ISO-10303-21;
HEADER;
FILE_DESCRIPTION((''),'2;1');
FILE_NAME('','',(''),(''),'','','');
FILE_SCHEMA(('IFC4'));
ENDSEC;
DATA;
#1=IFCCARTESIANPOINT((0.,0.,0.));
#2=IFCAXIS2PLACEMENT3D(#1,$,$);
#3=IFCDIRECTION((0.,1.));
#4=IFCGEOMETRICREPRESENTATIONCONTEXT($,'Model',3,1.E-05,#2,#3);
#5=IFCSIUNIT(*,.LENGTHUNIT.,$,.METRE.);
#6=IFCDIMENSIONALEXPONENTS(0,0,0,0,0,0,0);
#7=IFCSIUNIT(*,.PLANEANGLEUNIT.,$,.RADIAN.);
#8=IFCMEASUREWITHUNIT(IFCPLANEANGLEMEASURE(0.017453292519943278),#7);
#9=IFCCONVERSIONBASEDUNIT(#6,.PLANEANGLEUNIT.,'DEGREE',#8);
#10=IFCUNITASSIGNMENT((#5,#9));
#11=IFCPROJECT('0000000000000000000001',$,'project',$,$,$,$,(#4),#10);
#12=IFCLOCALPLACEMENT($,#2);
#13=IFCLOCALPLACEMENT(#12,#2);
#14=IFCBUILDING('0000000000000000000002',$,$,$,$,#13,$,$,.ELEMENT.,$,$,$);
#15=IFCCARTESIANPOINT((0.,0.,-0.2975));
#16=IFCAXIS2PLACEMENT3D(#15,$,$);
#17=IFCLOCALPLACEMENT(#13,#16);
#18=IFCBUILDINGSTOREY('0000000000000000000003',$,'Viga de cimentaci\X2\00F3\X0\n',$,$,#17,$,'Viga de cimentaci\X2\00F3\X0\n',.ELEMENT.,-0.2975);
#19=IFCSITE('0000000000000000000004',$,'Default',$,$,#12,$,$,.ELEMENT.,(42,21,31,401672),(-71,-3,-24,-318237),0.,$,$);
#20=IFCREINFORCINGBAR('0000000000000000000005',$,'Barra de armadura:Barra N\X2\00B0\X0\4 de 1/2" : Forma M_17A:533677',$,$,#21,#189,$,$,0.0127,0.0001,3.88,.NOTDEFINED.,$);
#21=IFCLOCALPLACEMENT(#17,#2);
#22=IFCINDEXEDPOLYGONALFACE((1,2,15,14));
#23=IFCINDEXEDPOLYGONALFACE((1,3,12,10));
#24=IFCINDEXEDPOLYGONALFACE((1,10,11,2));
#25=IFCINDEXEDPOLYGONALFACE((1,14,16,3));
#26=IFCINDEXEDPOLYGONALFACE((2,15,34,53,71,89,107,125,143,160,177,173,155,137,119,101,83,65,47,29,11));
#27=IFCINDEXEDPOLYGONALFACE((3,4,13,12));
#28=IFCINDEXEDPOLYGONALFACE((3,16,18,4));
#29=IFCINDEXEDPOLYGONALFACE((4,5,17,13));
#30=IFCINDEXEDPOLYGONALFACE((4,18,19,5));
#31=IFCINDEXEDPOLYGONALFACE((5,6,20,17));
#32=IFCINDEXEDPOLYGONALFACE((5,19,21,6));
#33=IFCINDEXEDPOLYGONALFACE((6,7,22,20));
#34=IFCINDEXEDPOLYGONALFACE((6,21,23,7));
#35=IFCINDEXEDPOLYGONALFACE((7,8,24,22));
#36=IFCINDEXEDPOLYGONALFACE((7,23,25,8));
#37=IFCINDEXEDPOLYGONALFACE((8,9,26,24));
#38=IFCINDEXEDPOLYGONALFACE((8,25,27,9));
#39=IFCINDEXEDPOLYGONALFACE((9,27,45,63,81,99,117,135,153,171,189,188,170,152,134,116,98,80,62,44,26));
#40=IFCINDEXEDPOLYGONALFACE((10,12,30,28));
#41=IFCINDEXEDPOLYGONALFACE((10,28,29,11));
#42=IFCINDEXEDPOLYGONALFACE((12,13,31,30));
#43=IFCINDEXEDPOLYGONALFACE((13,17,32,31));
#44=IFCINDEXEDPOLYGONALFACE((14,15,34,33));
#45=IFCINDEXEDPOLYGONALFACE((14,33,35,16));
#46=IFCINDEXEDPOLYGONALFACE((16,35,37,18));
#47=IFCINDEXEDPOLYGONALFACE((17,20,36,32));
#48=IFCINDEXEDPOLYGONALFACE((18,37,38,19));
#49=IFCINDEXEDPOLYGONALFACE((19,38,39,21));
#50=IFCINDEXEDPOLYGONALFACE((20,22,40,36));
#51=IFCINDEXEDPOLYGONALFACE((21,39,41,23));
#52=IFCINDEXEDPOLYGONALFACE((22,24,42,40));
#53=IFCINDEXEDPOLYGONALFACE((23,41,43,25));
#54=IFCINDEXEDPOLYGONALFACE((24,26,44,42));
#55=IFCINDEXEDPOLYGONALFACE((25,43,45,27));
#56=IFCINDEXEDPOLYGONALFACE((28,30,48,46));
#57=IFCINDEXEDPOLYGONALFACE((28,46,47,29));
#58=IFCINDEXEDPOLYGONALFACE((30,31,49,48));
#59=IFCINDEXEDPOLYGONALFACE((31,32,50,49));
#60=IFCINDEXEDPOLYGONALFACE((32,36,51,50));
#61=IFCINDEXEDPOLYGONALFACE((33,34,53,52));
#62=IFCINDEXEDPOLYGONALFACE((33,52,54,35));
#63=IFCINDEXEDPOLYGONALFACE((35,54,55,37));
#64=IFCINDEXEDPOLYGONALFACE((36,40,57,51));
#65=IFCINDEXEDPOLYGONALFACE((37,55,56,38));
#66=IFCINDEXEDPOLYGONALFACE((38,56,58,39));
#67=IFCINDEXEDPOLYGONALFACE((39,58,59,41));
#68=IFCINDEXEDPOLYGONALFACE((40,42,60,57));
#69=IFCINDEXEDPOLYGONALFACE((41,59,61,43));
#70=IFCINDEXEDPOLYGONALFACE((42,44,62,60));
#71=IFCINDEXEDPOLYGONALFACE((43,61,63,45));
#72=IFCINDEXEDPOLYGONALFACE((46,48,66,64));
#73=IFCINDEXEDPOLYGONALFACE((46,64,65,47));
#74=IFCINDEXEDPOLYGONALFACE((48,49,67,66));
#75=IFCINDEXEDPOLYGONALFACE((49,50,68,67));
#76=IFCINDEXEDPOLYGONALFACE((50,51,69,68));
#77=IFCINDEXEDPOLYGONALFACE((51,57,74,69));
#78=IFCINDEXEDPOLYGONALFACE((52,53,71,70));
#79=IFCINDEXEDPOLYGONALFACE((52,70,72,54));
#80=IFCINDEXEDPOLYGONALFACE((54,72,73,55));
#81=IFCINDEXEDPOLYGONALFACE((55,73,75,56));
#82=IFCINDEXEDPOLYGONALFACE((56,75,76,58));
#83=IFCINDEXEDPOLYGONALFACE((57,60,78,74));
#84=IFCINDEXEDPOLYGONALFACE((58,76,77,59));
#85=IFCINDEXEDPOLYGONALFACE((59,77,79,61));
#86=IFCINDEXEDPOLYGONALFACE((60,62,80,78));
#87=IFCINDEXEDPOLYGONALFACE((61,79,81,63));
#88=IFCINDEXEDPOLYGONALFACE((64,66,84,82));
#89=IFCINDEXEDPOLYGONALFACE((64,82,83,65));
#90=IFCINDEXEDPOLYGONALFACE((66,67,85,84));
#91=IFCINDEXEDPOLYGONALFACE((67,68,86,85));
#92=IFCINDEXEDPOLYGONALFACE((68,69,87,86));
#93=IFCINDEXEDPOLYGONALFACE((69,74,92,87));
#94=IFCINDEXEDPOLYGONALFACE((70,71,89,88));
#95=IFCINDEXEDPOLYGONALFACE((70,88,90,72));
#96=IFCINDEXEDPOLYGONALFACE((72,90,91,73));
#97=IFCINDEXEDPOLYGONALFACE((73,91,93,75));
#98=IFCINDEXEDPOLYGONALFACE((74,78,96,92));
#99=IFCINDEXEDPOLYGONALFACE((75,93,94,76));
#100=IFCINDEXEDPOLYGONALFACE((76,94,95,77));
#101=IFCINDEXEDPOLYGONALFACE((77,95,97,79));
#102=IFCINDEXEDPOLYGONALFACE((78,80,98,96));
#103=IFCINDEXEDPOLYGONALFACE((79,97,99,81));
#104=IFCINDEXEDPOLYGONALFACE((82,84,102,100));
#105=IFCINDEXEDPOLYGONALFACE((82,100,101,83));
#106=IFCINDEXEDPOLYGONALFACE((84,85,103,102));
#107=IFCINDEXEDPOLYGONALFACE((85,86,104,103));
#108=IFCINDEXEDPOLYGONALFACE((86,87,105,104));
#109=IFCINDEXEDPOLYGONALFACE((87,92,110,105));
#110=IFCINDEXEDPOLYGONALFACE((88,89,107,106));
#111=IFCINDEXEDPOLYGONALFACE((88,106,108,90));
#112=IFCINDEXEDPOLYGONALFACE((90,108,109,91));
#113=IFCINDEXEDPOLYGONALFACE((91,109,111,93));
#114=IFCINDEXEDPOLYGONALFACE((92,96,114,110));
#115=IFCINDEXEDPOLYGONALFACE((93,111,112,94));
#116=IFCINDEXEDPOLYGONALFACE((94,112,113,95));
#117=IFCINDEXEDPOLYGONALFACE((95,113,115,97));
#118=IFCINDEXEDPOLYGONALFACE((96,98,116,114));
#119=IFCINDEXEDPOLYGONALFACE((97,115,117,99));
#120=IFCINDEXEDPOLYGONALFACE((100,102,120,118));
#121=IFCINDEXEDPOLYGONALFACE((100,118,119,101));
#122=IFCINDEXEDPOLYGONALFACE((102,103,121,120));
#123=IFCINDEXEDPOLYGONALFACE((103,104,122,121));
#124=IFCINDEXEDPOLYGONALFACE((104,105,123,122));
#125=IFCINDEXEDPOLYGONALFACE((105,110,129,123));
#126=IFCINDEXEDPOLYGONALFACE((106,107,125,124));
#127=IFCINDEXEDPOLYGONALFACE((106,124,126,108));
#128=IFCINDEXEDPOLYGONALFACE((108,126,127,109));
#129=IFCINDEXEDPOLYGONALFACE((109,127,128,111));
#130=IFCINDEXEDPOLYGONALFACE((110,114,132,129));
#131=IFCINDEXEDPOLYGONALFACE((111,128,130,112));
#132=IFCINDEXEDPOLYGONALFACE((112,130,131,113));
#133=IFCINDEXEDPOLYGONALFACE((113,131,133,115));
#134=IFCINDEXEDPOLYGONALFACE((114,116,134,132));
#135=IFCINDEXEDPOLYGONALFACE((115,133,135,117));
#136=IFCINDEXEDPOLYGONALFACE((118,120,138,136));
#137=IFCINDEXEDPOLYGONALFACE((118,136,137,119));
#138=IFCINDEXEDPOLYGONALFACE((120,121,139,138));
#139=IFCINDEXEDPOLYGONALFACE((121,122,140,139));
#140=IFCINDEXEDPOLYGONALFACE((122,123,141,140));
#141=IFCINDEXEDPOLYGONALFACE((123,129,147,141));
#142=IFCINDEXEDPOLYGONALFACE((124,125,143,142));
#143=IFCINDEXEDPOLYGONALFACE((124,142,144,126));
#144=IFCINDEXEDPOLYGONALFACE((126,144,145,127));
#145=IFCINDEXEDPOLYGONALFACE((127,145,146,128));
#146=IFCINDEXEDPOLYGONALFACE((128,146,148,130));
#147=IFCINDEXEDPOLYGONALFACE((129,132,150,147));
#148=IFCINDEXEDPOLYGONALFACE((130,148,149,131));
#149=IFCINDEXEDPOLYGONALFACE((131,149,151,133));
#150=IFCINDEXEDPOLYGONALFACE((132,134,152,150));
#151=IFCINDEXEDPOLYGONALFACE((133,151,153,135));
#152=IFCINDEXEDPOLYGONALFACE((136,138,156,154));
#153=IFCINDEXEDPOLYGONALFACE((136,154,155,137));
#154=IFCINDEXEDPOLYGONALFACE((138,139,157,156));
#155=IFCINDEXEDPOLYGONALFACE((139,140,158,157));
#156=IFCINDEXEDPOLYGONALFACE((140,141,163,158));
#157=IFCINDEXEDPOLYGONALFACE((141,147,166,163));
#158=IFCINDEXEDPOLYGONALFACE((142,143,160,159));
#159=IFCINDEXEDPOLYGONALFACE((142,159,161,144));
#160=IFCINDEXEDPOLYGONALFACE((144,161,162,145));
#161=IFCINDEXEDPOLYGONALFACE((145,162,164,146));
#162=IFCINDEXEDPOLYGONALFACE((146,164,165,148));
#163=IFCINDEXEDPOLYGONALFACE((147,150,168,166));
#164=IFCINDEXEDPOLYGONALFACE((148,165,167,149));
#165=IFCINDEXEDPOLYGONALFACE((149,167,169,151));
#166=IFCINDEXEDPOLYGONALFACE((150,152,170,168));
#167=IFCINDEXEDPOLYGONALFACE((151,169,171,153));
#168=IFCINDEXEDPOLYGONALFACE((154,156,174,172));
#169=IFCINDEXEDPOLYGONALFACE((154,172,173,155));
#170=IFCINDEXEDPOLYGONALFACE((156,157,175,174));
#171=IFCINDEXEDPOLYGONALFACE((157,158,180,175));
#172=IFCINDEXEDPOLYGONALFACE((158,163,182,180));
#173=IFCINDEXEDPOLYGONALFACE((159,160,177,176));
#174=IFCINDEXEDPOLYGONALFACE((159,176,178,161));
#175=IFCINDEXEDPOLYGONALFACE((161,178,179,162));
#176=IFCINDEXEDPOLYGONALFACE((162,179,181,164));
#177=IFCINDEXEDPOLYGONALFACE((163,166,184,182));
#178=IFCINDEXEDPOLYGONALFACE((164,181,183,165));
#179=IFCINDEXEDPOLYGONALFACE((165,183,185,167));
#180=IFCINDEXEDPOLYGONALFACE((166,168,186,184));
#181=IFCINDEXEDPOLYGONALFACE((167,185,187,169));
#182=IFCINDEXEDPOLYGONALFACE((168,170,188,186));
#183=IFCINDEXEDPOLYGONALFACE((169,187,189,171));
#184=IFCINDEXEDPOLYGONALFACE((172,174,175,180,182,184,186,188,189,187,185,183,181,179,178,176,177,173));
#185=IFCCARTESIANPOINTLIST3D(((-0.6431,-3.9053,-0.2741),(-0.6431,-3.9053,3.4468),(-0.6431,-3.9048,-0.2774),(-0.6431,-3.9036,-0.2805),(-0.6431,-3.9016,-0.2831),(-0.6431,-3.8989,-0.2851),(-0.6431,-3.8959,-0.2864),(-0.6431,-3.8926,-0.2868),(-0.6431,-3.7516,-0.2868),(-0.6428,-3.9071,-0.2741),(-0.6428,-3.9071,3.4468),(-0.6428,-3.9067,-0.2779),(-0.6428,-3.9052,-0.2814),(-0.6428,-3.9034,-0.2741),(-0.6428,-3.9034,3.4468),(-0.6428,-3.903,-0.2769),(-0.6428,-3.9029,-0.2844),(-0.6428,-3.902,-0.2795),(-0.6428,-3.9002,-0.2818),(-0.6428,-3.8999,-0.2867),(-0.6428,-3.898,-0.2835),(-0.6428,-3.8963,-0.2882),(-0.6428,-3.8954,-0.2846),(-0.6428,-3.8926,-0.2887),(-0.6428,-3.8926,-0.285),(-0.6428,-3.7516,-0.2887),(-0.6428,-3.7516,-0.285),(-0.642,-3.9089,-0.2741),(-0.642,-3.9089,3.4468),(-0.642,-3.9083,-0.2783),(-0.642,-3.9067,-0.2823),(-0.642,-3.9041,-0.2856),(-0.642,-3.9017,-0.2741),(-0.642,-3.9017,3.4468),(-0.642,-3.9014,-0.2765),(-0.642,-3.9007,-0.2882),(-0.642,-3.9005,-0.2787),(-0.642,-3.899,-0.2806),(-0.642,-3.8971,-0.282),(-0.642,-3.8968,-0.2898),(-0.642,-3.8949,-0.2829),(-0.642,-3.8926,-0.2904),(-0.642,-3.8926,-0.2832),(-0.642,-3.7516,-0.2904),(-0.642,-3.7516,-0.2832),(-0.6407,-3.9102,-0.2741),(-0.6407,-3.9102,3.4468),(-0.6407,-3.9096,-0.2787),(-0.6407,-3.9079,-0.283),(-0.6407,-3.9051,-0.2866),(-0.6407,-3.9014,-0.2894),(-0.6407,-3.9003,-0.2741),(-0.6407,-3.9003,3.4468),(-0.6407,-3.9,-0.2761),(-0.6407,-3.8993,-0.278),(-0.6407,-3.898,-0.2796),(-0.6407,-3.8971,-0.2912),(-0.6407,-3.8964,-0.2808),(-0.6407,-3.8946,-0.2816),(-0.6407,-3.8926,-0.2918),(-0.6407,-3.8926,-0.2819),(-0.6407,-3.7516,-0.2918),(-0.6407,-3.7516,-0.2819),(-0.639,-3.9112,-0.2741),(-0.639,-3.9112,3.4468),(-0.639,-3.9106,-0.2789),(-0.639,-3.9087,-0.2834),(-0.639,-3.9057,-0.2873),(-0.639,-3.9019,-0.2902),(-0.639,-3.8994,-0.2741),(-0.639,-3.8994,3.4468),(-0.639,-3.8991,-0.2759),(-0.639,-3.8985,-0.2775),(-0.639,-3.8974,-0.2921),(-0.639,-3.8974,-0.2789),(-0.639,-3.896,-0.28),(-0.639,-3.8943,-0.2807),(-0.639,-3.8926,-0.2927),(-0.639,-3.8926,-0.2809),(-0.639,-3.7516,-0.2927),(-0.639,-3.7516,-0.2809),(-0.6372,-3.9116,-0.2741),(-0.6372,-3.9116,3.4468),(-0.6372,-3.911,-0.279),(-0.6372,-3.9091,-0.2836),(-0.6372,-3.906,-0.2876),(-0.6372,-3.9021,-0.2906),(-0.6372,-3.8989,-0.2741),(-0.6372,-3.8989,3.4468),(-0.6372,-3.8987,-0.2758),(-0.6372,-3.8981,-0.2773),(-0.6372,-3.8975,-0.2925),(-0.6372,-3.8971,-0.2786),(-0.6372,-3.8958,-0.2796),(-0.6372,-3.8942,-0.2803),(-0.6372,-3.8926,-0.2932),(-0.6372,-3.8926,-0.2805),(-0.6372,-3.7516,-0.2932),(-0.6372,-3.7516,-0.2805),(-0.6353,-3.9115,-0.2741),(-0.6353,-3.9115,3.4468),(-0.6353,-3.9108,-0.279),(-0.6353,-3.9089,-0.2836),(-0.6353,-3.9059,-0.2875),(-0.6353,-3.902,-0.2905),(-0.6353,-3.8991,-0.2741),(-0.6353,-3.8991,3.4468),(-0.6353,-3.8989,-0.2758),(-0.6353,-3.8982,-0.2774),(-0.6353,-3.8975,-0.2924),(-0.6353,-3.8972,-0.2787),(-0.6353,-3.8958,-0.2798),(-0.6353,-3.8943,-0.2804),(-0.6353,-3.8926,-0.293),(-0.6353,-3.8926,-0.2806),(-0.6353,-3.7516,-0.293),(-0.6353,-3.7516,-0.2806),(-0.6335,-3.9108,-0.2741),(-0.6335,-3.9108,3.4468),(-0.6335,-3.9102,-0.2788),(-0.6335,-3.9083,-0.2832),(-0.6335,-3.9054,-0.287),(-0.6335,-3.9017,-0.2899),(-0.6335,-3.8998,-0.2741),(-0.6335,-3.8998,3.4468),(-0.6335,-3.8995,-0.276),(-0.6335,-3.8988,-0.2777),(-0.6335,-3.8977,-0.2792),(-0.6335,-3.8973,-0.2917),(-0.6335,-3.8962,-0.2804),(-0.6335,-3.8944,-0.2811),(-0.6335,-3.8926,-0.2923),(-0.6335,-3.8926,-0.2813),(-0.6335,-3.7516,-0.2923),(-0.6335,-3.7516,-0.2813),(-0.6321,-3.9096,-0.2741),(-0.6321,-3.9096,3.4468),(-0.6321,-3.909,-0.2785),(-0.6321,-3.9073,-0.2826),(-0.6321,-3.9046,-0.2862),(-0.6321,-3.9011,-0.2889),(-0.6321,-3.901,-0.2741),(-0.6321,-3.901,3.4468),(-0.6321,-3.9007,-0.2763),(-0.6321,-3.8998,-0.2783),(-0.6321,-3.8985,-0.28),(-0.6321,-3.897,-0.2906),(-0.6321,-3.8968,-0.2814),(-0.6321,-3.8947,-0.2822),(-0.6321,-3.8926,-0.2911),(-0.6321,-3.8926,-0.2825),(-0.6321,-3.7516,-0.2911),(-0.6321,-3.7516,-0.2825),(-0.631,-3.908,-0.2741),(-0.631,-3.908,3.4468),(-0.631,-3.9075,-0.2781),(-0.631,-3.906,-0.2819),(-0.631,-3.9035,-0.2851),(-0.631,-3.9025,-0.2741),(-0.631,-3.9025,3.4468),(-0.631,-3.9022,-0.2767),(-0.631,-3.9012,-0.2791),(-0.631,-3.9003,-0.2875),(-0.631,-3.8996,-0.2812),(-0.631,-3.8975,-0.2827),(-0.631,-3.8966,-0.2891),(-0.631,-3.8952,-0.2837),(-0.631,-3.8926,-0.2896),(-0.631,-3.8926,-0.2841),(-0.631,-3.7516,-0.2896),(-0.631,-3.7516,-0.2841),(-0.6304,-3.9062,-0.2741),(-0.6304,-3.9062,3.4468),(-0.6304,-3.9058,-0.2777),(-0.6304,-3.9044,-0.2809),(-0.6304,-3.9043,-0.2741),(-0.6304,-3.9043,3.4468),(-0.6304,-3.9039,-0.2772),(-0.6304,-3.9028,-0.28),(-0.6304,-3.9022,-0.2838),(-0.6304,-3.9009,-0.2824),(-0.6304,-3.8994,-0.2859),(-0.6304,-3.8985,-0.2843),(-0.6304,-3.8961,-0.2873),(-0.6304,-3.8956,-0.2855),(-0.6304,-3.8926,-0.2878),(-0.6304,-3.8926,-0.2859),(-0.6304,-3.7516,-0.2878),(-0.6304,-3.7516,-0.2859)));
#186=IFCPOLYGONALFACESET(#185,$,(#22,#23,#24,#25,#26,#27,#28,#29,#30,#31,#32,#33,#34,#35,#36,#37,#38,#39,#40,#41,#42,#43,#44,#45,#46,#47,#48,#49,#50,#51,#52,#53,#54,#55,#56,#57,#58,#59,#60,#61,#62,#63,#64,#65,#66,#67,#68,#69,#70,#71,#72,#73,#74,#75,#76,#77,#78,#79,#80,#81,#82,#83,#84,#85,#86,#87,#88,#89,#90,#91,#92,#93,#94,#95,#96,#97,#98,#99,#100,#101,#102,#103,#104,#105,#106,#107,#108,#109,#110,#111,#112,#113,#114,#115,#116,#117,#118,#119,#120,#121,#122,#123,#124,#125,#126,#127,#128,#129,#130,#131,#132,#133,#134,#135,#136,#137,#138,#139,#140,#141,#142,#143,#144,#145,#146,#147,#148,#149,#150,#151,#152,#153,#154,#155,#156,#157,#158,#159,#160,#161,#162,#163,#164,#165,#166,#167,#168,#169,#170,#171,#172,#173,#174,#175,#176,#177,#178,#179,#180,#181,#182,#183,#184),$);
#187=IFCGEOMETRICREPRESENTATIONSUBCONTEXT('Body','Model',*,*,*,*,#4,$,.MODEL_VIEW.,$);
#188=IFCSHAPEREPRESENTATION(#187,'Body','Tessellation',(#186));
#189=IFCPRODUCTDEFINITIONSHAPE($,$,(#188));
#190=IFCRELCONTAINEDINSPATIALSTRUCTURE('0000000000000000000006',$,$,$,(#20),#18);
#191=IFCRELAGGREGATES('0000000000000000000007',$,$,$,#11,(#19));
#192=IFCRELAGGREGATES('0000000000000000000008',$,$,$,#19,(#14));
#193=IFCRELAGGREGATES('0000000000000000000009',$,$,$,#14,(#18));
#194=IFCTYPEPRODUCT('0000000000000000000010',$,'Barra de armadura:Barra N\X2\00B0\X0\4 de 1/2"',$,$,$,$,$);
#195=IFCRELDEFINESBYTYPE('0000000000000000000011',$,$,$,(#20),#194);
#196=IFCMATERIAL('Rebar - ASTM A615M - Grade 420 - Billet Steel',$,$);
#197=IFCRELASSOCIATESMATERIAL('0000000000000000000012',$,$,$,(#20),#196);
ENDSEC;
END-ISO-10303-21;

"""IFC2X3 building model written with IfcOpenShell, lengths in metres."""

from ifc_helpers import new_model, entity, si_unit, converted_unit, direction, frame, origin, place, context, subcontext, project, spatial, material, type_object, element, save


model = new_model("IFC2X3")

# Units and contexts
model_context = context("Model", 3, precision=1e-05, world=origin(), true_north=direction((0.0, 1.0)))
body_context = subcontext(model_context, "Body", "Model", "MODEL_VIEW")
ifc_project = project(units=[si_unit("LENGTHUNIT", "METRE"), converted_unit("PLANEANGLEUNIT", "DEGREE", entity("IfcPlaneAngleMeasure", 0.017453292519943278), si_unit("PLANEANGLEUNIT", "RADIAN"), dimensions=[0, 0, 0, 0, 0, 0, 0])], contexts=[model_context])

# Site, building, storey
site_placement = place(None, origin())
site = spatial("IfcSite", under=ifc_project, at=site_placement, Name="Default", CompositionType="ELEMENT", RefLatitude=(42, 21, 31, 401672), RefLongitude=(-71, -3, -24, -318237), RefElevation=0.0)
building_placement = place(site_placement, origin())
building = spatial("IfcBuilding", under=site, at=building_placement, CompositionType="ELEMENT")
storey_placement = place(building_placement, frame((0.0, 0.0, -0.2975)))
storey = spatial("IfcBuildingStorey", under=building, at=storey_placement, Name="Viga de cimentación", LongName="Viga de cimentación", CompositionType="ELEMENT", Elevation=-0.2975)

# Reinforcing bar
ifc_material = material(Name="Rebar - ASTM A615M - Grade 420 - Billet Steel")
type_product_1 = type_object("IfcTypeProduct", Name="Barra de armadura:Barra N°4 de 1/2\"")
reinforcing_bar_1_placement = place(storey_placement, origin())
element("IfcReinforcingBar", 1, at=reinforcing_bar_1_placement, inside=storey, type_object=type_product_1, material=ifc_material, Name="Barra de armadura:Barra N°4 de 1/2\" : Forma M_17A:533677", BarLength=3.88, BarRole="NOTDEFINED", CrossSectionArea=0.0001, NominalDiameter=0.0127, context=body_context, shape_type="AdvancedSweptSolid", body=[
    entity("IfcSweptDiskSolid", entity("IfcCompositeCurve", [entity("IfcCompositeCurveSegment", "CONTINUOUS", True, entity("IfcPolyline", [entity("IfcCartesianPoint", [-0.6367, -3.9053, 3.4468]), entity("IfcCartesianPoint", [-0.6367, -3.9053, -0.2741])])), entity("IfcCompositeCurveSegment", "CONTINUOUS", True, entity("IfcTrimmedCurve", entity("IfcCircle", entity("IfcAxis2Placement3D", entity("IfcCartesianPoint", [-0.6367, -3.8926, -0.2741]), entity("IfcDirection", [1.0, 0.0, 0.0]), entity("IfcDirection", [0.0, 0.0, -1.0])), 0.0127), [entity("IfcParameterValue", 270.0)], [entity("IfcParameterValue", 360.0)], True, "PARAMETER")), entity("IfcCompositeCurveSegment", "CONTINUOUS", True, entity("IfcPolyline", [entity("IfcCartesianPoint", [-0.6367, -3.8926, -0.2868]), entity("IfcCartesianPoint", [-0.6367, -3.7516, -0.2868])]))], False), 0.0063, None, 0.0, 92.0),
])

save(model, "model.ifc")
